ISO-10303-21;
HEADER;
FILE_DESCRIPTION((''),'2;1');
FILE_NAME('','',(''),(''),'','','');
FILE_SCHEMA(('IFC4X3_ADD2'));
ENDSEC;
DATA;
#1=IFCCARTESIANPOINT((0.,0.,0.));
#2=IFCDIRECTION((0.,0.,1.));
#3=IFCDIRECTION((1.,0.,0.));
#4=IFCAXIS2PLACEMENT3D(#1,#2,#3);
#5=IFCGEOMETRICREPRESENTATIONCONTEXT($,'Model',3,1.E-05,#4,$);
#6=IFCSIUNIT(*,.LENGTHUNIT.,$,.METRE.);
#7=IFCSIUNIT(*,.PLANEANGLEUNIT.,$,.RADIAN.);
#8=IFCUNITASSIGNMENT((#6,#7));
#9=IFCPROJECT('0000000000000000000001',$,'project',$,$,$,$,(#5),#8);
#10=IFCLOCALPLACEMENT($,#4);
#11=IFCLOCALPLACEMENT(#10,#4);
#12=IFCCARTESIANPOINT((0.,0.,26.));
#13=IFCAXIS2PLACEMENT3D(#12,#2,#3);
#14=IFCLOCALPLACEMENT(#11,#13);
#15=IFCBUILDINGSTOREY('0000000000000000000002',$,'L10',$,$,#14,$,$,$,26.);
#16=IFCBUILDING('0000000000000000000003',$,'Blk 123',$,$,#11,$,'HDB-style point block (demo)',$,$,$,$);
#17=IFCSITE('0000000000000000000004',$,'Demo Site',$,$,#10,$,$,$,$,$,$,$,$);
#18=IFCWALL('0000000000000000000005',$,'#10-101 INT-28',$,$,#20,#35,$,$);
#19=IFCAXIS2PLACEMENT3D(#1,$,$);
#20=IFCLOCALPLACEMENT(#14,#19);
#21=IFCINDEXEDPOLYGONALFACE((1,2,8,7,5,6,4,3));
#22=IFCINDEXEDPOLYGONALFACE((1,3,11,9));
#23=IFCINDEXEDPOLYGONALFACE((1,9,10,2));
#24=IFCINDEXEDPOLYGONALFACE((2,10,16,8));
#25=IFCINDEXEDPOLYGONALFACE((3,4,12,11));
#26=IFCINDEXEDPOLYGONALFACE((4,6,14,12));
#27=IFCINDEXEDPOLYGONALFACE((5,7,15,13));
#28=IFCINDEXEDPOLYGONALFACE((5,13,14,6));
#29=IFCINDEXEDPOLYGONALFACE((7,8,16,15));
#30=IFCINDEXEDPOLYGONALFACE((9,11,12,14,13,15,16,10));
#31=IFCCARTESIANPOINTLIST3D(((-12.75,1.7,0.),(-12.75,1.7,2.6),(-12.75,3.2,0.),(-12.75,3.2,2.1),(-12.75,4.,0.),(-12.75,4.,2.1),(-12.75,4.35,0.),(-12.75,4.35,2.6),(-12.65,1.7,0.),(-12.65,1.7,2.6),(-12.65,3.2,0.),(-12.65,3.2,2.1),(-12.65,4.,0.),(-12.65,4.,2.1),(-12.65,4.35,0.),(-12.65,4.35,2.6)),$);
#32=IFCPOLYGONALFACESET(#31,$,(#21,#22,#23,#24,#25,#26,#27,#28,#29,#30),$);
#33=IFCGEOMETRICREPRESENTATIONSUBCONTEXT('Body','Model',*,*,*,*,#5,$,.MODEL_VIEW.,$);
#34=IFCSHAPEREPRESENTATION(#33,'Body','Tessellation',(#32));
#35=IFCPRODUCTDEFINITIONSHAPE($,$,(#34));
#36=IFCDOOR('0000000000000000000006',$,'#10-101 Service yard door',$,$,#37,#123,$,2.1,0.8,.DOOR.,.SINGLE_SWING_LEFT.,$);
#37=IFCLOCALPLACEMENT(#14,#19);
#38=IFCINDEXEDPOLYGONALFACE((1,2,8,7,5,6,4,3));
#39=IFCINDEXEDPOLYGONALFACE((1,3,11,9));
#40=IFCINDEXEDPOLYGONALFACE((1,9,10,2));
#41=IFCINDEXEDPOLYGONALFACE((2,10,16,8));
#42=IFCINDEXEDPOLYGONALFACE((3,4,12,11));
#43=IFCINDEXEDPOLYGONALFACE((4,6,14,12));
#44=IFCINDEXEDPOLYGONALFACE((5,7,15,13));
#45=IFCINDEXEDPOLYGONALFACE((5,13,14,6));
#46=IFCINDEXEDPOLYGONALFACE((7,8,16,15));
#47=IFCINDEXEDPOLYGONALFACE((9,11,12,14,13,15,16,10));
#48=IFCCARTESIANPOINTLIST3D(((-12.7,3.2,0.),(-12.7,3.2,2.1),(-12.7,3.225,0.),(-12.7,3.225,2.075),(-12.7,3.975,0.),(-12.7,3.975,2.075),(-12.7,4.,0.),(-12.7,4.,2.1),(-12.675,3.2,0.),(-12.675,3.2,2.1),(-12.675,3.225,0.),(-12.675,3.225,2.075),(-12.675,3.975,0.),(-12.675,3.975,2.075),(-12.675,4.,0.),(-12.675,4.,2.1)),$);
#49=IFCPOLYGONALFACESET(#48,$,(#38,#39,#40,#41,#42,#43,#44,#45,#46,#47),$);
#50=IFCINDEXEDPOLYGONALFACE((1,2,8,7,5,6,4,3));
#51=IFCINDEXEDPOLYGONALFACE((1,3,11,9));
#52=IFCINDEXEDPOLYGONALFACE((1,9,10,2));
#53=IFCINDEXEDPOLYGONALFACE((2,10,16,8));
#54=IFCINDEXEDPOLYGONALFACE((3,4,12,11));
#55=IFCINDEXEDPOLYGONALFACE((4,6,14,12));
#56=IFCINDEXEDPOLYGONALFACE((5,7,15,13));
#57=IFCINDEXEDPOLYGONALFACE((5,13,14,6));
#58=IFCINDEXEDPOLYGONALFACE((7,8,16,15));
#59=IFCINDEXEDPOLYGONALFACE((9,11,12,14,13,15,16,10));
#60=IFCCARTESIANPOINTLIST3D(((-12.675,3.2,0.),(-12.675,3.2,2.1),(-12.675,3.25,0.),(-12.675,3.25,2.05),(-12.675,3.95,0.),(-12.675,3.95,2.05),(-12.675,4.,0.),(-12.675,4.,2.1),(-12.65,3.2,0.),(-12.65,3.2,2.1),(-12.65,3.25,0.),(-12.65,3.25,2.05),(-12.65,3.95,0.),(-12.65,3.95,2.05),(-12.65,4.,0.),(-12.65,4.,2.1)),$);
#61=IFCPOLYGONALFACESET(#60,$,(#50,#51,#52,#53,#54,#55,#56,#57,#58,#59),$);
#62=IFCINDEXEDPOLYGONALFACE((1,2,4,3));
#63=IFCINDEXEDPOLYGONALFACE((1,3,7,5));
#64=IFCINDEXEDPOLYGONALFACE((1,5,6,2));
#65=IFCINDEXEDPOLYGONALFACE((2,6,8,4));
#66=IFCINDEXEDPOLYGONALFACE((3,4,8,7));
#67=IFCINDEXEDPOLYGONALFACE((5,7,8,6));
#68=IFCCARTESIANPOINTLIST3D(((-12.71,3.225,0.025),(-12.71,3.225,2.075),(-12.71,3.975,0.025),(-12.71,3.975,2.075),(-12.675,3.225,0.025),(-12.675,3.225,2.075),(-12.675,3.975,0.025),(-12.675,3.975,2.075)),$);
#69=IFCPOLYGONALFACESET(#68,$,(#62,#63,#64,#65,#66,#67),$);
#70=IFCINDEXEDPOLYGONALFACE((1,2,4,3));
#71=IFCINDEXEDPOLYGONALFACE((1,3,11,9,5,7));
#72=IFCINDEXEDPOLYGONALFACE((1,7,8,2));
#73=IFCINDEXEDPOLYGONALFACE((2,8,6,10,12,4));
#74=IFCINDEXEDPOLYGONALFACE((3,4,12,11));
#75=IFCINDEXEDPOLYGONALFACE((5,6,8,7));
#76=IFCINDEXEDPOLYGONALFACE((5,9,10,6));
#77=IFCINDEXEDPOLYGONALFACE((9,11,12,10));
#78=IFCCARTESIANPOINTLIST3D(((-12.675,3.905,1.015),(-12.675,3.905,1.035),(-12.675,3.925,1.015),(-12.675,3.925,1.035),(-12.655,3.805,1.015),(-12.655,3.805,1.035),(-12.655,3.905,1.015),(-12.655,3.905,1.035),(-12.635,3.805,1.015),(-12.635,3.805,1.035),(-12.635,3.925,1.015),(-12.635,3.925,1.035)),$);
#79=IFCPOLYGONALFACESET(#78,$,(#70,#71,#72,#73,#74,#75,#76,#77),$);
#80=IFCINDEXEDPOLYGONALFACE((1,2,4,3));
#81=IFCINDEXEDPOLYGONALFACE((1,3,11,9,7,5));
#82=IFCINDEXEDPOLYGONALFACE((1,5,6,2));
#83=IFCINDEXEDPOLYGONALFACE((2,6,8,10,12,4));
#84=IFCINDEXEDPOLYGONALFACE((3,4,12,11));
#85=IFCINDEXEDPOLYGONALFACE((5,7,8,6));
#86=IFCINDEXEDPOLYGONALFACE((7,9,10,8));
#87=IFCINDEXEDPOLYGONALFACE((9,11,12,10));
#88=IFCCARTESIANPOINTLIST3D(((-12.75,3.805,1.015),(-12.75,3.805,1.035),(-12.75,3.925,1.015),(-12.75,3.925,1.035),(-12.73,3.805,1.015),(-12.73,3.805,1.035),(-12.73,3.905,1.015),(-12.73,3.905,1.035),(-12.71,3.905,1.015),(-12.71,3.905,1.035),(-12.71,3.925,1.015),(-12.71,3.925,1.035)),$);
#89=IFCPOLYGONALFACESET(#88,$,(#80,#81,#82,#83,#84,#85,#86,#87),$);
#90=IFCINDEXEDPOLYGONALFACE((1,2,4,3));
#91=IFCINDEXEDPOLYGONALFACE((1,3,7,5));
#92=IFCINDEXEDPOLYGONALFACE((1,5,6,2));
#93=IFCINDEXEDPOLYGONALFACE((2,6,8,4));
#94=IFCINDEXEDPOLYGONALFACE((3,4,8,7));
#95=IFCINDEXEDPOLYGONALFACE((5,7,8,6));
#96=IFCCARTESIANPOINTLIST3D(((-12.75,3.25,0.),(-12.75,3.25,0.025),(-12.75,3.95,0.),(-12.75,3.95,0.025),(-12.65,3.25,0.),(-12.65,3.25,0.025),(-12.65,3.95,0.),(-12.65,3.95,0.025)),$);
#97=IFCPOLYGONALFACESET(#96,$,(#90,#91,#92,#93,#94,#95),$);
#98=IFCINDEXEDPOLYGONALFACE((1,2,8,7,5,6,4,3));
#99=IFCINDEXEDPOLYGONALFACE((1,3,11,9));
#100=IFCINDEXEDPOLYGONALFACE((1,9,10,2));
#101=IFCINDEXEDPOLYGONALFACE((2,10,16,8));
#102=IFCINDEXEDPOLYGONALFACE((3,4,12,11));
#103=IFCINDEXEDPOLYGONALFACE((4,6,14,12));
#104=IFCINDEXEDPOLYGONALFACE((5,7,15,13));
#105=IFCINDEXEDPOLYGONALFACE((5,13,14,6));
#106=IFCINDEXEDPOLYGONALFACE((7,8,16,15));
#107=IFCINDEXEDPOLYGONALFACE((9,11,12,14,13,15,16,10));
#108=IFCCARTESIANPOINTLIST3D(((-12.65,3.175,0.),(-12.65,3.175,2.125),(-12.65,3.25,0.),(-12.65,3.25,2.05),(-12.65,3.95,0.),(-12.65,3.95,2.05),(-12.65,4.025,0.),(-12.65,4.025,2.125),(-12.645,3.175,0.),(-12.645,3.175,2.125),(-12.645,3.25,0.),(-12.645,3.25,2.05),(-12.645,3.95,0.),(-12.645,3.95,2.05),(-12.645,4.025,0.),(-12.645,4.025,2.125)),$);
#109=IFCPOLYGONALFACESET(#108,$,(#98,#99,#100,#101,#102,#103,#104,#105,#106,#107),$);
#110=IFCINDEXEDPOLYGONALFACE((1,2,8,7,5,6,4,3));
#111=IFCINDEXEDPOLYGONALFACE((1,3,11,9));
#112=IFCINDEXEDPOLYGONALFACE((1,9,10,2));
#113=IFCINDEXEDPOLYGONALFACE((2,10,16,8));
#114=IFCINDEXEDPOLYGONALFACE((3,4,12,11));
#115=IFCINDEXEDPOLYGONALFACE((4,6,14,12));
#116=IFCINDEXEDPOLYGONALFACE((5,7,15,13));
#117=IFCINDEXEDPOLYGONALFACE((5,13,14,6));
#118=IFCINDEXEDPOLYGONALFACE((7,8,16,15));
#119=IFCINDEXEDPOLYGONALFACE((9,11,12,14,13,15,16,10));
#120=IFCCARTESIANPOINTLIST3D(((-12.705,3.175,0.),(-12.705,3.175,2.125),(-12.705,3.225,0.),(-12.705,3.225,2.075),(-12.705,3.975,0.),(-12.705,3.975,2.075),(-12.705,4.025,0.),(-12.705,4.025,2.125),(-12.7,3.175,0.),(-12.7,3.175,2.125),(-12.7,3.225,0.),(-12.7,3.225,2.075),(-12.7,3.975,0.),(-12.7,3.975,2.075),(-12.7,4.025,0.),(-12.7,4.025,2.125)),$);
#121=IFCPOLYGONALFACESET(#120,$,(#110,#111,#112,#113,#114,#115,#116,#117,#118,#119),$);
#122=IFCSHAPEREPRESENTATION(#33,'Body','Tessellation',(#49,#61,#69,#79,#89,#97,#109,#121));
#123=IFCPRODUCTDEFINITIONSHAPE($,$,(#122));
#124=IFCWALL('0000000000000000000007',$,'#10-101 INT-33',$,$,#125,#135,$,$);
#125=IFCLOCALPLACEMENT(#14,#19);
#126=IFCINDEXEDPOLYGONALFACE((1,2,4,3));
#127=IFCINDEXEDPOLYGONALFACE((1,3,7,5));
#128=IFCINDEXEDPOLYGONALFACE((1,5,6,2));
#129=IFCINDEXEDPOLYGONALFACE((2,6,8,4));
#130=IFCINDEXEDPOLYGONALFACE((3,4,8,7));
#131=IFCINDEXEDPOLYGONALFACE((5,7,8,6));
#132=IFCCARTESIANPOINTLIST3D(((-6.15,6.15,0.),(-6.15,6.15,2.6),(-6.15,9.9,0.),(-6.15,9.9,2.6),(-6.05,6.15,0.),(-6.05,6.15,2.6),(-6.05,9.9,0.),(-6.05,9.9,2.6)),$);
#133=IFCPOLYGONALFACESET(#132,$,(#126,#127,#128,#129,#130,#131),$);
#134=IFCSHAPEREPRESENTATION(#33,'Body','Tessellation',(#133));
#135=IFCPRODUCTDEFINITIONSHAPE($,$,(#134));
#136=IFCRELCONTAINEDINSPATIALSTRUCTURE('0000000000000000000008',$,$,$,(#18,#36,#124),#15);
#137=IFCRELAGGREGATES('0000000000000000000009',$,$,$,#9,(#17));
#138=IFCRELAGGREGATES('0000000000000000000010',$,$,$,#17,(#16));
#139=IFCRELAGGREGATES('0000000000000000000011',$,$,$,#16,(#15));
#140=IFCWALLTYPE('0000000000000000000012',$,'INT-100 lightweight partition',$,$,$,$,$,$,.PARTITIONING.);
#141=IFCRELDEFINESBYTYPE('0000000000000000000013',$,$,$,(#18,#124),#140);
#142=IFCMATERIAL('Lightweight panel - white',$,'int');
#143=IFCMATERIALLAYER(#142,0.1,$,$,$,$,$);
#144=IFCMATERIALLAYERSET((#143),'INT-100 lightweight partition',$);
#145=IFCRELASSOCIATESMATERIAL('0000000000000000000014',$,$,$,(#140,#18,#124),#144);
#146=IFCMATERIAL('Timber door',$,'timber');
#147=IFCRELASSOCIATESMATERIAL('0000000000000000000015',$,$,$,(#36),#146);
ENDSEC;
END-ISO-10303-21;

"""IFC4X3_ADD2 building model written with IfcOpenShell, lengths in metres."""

from ifc_helpers import new_model, si_unit, frame, origin_with_axes, place, context, subcontext, project, spatial, line, indexed_curve, outline, extrude, material, layer, layer_set, layer_usage, type_object, element, fill, save


model = new_model("IFC4X3_ADD2")

# Units and contexts
model_context = context("Model", 3, precision=1e-05, world=origin_with_axes())
body_context = subcontext(model_context, "Body", "Model", "MODEL_VIEW")
ifc_project = project(units=[si_unit("LENGTHUNIT", "METRE"), si_unit("PLANEANGLEUNIT", "RADIAN")], contexts=[model_context])

# Site, building, storey
site_placement = place(None, origin_with_axes())
site = spatial("IfcSite", under=ifc_project, at=site_placement, Name="Demo Site")
building_placement = place(site_placement, origin_with_axes())
building = spatial("IfcBuilding", under=site, at=building_placement, Name="Blk 123", LongName="HDB-style point block (demo)")
storey_placement = place(building_placement, frame((0.0, 0.0, 26.0), z_axis=(0.0, 0.0, 1.0), x_axis=(1.0, 0.0, 0.0)))
storey = spatial("IfcBuildingStorey", under=building, at=storey_placement, Name="L10", Elevation=26.0)

# Shared definitions
ifc_material_1 = material(Name="Timber door", Category="timber")

# Shared definitions
ifc_material_2 = material(Name="Lightweight panel - white", Category="int")
ifc_layer_1 = layer(ifc_material_2, 0.1)
ifc_layer_set_1 = layer_set([ifc_layer_1], Name="INT-100 lightweight partition")
ifc_layer_usage_1 = layer_usage(ifc_layer_set_1, "AXIS2", "POSITIVE", -0.05)
wall_type_1 = type_object("IfcWallType", Name="INT-100 lightweight partition", PredefinedType="PARTITIONING", material=ifc_layer_set_1)

# Wall, opening, door
wall_1_placement = place(storey_placement, frame((-12.7, 1.7, 0.0), z_axis=(0.0, 0.0, 1.0), x_axis=(0.0, 1.0, 0.0)))
wall_1 = element("IfcWall", 1, at=wall_1_placement, inside=storey, type_object=wall_type_1, material=ifc_layer_usage_1, Name="#10-101 INT-28", context=body_context, shape_type="SweptSolid", body=[
    extrude(outline(indexed_curve([(0.0, 0.0), (0.0, 0.1), (2.65, 0.1), (2.65, 0.0), (0.0, 0.0)], self_intersect=False)), frame((0.0, -0.05, 0.0), z_axis=(0.0, 0.0, 1.0), x_axis=(1.0, 0.0, 0.0)), (0.0, 0.0, 1.0), 2.6),
])
opening_1_placement = place(wall_1_placement, frame((1.5, -0.15, 0.0), z_axis=(0.0, 0.0, 1.0), x_axis=(1.0, 0.0, 0.0)))
opening_1 = element("IfcOpeningElement", 2, at=opening_1_placement, cuts=wall_1, context=body_context, shape_type="SweptSolid", body=[
    extrude(outline(indexed_curve([(0.0, 0.0), (0.0, 0.3), (0.8, 0.3), (0.8, 0.0), (0.0, 0.0)], self_intersect=False)), origin_with_axes(), (0.0, 0.0, 1.0), 2.1),
])
door_1_placement = place(opening_1_placement, frame((0.0, 0.1, 0.0), z_axis=(0.0, 0.0, 1.0), x_axis=(1.0, 0.0, 0.0)))
door_1 = element("IfcDoor", 3, at=door_1_placement, inside=storey, material=ifc_material_1, Name="#10-101 Service yard door", OperationType="SINGLE_SWING_LEFT", OverallHeight=2.1, OverallWidth=0.8, PredefinedType="DOOR", context=body_context, shape_type="SweptSolid", body=[
    extrude(outline(indexed_curve([(0.0, 0.0), (0.0, 2.1), (0.8, 2.1), (0.8, 0.0), (0.775, 0.0), (0.775, 2.075), (0.025, 2.075), (0.025, 0.0)], segments=[line(1, 2, 3, 4, 5, 6, 7, 8, 1)])), frame((0.0, 0.025, 0.0), z_axis=(0.0, -1.0, 0.0), x_axis=(1.0, 0.0, 0.0)), (0.0, 0.0, -1.0), 0.025),
    extrude(outline(indexed_curve([(0.0, 0.0), (0.0, 2.1), (0.8, 2.1), (0.8, 0.0), (0.75, 0.0), (0.75, 2.05), (0.05, 2.05), (0.05, 0.0)], segments=[line(1, 2, 3, 4, 5, 6, 7, 8, 1)])), frame((0.0, 0.0, 0.0), z_axis=(0.0, -1.0, 0.0), x_axis=(1.0, 0.0, 0.0)), (0.0, 0.0, -1.0), 0.025),
    extrude(outline(indexed_curve([(0.0, 0.0), (0.75, 0.0), (0.75, 0.035), (0.0, 0.035)], segments=[line(1, 2, 3, 4, 1)])), frame((0.025, 0.025, 0.025), z_axis=(0.0, 0.0, 1.0), x_axis=(1.0, 0.0, 0.0)), (0.0, 0.0, 1.0), 2.05),
    extrude(outline(indexed_curve([(0.0, 0.0), (0.0, -0.04), (-0.12, -0.04), (-0.12, -0.02), (-0.02, -0.02), (-0.02, 0.0)], segments=[line(1, 2, 3, 4, 5, 6, 1)])), frame((0.725, 0.025, 1.015), z_axis=(0.0, 0.0, 1.0), x_axis=(1.0, 0.0, 0.0)), (0.0, 0.0, 1.0), 0.02),
    extrude(outline(indexed_curve([(0.0, 0.0), (0.0, 0.04), (-0.12, 0.04), (-0.12, 0.02), (-0.02, 0.02), (-0.02, 0.0)], segments=[line(1, 2, 3, 4, 5, 6, 1)])), frame((0.725, 0.06, 1.015), z_axis=(0.0, 0.0, 1.0), x_axis=(1.0, 0.0, 0.0)), (0.0, 0.0, 1.0), 0.02),
    extrude(outline(indexed_curve([(0.0, 0.0), (0.7, 0.0), (0.7, 0.1), (0.0, 0.1)], segments=[line(1, 2, 3, 4, 1)])), frame((0.05, 0.0, 0.0), z_axis=(0.0, 0.0, 1.0), x_axis=(1.0, 0.0, 0.0)), (0.0, 0.0, 1.0), 0.025),
    extrude(outline(indexed_curve([(0.0, 0.0), (0.0, 2.125), (0.85, 2.125), (0.85, 0.0), (0.775, 0.0), (0.775, 2.05), (0.075, 2.05), (0.075, 0.0)], segments=[line(1, 2, 3, 4, 5, 6, 7, 8, 1)])), frame((-0.025, -0.005, 0.0), z_axis=(0.0, -1.0, 0.0), x_axis=(1.0, 0.0, 0.0)), (0.0, 0.0, -1.0), 0.005),
    extrude(outline(indexed_curve([(0.0, 0.0), (0.0, 2.125), (0.85, 2.125), (0.85, 0.0), (0.8, 0.0), (0.8, 2.075), (0.05, 2.075), (0.05, 0.0)], segments=[line(1, 2, 3, 4, 5, 6, 7, 8, 1)])), frame((-0.025, 0.05, 0.0), z_axis=(0.0, -1.0, 0.0), x_axis=(1.0, 0.0, 0.0)), (0.0, 0.0, -1.0), 0.005),
])
fill(opening_1, door_1)

# Wall
wall_2_placement = place(storey_placement, frame((-6.1, 6.15, 0.0), z_axis=(0.0, 0.0, 1.0), x_axis=(0.0, 1.0, 0.0)))
element("IfcWall", 4, at=wall_2_placement, inside=storey, type_object=wall_type_1, material=ifc_layer_usage_1, Name="#10-101 INT-33", context=body_context, shape_type="SweptSolid", body=[
    extrude(outline(indexed_curve([(0.0, 0.0), (0.0, 0.1), (3.75, 0.1), (3.75, 0.0), (0.0, 0.0)], self_intersect=False)), frame((0.0, -0.05, 0.0), z_axis=(0.0, 0.0, 1.0), x_axis=(1.0, 0.0, 0.0)), (0.0, 0.0, 1.0), 2.6),
])

save(model, "model.ifc")
